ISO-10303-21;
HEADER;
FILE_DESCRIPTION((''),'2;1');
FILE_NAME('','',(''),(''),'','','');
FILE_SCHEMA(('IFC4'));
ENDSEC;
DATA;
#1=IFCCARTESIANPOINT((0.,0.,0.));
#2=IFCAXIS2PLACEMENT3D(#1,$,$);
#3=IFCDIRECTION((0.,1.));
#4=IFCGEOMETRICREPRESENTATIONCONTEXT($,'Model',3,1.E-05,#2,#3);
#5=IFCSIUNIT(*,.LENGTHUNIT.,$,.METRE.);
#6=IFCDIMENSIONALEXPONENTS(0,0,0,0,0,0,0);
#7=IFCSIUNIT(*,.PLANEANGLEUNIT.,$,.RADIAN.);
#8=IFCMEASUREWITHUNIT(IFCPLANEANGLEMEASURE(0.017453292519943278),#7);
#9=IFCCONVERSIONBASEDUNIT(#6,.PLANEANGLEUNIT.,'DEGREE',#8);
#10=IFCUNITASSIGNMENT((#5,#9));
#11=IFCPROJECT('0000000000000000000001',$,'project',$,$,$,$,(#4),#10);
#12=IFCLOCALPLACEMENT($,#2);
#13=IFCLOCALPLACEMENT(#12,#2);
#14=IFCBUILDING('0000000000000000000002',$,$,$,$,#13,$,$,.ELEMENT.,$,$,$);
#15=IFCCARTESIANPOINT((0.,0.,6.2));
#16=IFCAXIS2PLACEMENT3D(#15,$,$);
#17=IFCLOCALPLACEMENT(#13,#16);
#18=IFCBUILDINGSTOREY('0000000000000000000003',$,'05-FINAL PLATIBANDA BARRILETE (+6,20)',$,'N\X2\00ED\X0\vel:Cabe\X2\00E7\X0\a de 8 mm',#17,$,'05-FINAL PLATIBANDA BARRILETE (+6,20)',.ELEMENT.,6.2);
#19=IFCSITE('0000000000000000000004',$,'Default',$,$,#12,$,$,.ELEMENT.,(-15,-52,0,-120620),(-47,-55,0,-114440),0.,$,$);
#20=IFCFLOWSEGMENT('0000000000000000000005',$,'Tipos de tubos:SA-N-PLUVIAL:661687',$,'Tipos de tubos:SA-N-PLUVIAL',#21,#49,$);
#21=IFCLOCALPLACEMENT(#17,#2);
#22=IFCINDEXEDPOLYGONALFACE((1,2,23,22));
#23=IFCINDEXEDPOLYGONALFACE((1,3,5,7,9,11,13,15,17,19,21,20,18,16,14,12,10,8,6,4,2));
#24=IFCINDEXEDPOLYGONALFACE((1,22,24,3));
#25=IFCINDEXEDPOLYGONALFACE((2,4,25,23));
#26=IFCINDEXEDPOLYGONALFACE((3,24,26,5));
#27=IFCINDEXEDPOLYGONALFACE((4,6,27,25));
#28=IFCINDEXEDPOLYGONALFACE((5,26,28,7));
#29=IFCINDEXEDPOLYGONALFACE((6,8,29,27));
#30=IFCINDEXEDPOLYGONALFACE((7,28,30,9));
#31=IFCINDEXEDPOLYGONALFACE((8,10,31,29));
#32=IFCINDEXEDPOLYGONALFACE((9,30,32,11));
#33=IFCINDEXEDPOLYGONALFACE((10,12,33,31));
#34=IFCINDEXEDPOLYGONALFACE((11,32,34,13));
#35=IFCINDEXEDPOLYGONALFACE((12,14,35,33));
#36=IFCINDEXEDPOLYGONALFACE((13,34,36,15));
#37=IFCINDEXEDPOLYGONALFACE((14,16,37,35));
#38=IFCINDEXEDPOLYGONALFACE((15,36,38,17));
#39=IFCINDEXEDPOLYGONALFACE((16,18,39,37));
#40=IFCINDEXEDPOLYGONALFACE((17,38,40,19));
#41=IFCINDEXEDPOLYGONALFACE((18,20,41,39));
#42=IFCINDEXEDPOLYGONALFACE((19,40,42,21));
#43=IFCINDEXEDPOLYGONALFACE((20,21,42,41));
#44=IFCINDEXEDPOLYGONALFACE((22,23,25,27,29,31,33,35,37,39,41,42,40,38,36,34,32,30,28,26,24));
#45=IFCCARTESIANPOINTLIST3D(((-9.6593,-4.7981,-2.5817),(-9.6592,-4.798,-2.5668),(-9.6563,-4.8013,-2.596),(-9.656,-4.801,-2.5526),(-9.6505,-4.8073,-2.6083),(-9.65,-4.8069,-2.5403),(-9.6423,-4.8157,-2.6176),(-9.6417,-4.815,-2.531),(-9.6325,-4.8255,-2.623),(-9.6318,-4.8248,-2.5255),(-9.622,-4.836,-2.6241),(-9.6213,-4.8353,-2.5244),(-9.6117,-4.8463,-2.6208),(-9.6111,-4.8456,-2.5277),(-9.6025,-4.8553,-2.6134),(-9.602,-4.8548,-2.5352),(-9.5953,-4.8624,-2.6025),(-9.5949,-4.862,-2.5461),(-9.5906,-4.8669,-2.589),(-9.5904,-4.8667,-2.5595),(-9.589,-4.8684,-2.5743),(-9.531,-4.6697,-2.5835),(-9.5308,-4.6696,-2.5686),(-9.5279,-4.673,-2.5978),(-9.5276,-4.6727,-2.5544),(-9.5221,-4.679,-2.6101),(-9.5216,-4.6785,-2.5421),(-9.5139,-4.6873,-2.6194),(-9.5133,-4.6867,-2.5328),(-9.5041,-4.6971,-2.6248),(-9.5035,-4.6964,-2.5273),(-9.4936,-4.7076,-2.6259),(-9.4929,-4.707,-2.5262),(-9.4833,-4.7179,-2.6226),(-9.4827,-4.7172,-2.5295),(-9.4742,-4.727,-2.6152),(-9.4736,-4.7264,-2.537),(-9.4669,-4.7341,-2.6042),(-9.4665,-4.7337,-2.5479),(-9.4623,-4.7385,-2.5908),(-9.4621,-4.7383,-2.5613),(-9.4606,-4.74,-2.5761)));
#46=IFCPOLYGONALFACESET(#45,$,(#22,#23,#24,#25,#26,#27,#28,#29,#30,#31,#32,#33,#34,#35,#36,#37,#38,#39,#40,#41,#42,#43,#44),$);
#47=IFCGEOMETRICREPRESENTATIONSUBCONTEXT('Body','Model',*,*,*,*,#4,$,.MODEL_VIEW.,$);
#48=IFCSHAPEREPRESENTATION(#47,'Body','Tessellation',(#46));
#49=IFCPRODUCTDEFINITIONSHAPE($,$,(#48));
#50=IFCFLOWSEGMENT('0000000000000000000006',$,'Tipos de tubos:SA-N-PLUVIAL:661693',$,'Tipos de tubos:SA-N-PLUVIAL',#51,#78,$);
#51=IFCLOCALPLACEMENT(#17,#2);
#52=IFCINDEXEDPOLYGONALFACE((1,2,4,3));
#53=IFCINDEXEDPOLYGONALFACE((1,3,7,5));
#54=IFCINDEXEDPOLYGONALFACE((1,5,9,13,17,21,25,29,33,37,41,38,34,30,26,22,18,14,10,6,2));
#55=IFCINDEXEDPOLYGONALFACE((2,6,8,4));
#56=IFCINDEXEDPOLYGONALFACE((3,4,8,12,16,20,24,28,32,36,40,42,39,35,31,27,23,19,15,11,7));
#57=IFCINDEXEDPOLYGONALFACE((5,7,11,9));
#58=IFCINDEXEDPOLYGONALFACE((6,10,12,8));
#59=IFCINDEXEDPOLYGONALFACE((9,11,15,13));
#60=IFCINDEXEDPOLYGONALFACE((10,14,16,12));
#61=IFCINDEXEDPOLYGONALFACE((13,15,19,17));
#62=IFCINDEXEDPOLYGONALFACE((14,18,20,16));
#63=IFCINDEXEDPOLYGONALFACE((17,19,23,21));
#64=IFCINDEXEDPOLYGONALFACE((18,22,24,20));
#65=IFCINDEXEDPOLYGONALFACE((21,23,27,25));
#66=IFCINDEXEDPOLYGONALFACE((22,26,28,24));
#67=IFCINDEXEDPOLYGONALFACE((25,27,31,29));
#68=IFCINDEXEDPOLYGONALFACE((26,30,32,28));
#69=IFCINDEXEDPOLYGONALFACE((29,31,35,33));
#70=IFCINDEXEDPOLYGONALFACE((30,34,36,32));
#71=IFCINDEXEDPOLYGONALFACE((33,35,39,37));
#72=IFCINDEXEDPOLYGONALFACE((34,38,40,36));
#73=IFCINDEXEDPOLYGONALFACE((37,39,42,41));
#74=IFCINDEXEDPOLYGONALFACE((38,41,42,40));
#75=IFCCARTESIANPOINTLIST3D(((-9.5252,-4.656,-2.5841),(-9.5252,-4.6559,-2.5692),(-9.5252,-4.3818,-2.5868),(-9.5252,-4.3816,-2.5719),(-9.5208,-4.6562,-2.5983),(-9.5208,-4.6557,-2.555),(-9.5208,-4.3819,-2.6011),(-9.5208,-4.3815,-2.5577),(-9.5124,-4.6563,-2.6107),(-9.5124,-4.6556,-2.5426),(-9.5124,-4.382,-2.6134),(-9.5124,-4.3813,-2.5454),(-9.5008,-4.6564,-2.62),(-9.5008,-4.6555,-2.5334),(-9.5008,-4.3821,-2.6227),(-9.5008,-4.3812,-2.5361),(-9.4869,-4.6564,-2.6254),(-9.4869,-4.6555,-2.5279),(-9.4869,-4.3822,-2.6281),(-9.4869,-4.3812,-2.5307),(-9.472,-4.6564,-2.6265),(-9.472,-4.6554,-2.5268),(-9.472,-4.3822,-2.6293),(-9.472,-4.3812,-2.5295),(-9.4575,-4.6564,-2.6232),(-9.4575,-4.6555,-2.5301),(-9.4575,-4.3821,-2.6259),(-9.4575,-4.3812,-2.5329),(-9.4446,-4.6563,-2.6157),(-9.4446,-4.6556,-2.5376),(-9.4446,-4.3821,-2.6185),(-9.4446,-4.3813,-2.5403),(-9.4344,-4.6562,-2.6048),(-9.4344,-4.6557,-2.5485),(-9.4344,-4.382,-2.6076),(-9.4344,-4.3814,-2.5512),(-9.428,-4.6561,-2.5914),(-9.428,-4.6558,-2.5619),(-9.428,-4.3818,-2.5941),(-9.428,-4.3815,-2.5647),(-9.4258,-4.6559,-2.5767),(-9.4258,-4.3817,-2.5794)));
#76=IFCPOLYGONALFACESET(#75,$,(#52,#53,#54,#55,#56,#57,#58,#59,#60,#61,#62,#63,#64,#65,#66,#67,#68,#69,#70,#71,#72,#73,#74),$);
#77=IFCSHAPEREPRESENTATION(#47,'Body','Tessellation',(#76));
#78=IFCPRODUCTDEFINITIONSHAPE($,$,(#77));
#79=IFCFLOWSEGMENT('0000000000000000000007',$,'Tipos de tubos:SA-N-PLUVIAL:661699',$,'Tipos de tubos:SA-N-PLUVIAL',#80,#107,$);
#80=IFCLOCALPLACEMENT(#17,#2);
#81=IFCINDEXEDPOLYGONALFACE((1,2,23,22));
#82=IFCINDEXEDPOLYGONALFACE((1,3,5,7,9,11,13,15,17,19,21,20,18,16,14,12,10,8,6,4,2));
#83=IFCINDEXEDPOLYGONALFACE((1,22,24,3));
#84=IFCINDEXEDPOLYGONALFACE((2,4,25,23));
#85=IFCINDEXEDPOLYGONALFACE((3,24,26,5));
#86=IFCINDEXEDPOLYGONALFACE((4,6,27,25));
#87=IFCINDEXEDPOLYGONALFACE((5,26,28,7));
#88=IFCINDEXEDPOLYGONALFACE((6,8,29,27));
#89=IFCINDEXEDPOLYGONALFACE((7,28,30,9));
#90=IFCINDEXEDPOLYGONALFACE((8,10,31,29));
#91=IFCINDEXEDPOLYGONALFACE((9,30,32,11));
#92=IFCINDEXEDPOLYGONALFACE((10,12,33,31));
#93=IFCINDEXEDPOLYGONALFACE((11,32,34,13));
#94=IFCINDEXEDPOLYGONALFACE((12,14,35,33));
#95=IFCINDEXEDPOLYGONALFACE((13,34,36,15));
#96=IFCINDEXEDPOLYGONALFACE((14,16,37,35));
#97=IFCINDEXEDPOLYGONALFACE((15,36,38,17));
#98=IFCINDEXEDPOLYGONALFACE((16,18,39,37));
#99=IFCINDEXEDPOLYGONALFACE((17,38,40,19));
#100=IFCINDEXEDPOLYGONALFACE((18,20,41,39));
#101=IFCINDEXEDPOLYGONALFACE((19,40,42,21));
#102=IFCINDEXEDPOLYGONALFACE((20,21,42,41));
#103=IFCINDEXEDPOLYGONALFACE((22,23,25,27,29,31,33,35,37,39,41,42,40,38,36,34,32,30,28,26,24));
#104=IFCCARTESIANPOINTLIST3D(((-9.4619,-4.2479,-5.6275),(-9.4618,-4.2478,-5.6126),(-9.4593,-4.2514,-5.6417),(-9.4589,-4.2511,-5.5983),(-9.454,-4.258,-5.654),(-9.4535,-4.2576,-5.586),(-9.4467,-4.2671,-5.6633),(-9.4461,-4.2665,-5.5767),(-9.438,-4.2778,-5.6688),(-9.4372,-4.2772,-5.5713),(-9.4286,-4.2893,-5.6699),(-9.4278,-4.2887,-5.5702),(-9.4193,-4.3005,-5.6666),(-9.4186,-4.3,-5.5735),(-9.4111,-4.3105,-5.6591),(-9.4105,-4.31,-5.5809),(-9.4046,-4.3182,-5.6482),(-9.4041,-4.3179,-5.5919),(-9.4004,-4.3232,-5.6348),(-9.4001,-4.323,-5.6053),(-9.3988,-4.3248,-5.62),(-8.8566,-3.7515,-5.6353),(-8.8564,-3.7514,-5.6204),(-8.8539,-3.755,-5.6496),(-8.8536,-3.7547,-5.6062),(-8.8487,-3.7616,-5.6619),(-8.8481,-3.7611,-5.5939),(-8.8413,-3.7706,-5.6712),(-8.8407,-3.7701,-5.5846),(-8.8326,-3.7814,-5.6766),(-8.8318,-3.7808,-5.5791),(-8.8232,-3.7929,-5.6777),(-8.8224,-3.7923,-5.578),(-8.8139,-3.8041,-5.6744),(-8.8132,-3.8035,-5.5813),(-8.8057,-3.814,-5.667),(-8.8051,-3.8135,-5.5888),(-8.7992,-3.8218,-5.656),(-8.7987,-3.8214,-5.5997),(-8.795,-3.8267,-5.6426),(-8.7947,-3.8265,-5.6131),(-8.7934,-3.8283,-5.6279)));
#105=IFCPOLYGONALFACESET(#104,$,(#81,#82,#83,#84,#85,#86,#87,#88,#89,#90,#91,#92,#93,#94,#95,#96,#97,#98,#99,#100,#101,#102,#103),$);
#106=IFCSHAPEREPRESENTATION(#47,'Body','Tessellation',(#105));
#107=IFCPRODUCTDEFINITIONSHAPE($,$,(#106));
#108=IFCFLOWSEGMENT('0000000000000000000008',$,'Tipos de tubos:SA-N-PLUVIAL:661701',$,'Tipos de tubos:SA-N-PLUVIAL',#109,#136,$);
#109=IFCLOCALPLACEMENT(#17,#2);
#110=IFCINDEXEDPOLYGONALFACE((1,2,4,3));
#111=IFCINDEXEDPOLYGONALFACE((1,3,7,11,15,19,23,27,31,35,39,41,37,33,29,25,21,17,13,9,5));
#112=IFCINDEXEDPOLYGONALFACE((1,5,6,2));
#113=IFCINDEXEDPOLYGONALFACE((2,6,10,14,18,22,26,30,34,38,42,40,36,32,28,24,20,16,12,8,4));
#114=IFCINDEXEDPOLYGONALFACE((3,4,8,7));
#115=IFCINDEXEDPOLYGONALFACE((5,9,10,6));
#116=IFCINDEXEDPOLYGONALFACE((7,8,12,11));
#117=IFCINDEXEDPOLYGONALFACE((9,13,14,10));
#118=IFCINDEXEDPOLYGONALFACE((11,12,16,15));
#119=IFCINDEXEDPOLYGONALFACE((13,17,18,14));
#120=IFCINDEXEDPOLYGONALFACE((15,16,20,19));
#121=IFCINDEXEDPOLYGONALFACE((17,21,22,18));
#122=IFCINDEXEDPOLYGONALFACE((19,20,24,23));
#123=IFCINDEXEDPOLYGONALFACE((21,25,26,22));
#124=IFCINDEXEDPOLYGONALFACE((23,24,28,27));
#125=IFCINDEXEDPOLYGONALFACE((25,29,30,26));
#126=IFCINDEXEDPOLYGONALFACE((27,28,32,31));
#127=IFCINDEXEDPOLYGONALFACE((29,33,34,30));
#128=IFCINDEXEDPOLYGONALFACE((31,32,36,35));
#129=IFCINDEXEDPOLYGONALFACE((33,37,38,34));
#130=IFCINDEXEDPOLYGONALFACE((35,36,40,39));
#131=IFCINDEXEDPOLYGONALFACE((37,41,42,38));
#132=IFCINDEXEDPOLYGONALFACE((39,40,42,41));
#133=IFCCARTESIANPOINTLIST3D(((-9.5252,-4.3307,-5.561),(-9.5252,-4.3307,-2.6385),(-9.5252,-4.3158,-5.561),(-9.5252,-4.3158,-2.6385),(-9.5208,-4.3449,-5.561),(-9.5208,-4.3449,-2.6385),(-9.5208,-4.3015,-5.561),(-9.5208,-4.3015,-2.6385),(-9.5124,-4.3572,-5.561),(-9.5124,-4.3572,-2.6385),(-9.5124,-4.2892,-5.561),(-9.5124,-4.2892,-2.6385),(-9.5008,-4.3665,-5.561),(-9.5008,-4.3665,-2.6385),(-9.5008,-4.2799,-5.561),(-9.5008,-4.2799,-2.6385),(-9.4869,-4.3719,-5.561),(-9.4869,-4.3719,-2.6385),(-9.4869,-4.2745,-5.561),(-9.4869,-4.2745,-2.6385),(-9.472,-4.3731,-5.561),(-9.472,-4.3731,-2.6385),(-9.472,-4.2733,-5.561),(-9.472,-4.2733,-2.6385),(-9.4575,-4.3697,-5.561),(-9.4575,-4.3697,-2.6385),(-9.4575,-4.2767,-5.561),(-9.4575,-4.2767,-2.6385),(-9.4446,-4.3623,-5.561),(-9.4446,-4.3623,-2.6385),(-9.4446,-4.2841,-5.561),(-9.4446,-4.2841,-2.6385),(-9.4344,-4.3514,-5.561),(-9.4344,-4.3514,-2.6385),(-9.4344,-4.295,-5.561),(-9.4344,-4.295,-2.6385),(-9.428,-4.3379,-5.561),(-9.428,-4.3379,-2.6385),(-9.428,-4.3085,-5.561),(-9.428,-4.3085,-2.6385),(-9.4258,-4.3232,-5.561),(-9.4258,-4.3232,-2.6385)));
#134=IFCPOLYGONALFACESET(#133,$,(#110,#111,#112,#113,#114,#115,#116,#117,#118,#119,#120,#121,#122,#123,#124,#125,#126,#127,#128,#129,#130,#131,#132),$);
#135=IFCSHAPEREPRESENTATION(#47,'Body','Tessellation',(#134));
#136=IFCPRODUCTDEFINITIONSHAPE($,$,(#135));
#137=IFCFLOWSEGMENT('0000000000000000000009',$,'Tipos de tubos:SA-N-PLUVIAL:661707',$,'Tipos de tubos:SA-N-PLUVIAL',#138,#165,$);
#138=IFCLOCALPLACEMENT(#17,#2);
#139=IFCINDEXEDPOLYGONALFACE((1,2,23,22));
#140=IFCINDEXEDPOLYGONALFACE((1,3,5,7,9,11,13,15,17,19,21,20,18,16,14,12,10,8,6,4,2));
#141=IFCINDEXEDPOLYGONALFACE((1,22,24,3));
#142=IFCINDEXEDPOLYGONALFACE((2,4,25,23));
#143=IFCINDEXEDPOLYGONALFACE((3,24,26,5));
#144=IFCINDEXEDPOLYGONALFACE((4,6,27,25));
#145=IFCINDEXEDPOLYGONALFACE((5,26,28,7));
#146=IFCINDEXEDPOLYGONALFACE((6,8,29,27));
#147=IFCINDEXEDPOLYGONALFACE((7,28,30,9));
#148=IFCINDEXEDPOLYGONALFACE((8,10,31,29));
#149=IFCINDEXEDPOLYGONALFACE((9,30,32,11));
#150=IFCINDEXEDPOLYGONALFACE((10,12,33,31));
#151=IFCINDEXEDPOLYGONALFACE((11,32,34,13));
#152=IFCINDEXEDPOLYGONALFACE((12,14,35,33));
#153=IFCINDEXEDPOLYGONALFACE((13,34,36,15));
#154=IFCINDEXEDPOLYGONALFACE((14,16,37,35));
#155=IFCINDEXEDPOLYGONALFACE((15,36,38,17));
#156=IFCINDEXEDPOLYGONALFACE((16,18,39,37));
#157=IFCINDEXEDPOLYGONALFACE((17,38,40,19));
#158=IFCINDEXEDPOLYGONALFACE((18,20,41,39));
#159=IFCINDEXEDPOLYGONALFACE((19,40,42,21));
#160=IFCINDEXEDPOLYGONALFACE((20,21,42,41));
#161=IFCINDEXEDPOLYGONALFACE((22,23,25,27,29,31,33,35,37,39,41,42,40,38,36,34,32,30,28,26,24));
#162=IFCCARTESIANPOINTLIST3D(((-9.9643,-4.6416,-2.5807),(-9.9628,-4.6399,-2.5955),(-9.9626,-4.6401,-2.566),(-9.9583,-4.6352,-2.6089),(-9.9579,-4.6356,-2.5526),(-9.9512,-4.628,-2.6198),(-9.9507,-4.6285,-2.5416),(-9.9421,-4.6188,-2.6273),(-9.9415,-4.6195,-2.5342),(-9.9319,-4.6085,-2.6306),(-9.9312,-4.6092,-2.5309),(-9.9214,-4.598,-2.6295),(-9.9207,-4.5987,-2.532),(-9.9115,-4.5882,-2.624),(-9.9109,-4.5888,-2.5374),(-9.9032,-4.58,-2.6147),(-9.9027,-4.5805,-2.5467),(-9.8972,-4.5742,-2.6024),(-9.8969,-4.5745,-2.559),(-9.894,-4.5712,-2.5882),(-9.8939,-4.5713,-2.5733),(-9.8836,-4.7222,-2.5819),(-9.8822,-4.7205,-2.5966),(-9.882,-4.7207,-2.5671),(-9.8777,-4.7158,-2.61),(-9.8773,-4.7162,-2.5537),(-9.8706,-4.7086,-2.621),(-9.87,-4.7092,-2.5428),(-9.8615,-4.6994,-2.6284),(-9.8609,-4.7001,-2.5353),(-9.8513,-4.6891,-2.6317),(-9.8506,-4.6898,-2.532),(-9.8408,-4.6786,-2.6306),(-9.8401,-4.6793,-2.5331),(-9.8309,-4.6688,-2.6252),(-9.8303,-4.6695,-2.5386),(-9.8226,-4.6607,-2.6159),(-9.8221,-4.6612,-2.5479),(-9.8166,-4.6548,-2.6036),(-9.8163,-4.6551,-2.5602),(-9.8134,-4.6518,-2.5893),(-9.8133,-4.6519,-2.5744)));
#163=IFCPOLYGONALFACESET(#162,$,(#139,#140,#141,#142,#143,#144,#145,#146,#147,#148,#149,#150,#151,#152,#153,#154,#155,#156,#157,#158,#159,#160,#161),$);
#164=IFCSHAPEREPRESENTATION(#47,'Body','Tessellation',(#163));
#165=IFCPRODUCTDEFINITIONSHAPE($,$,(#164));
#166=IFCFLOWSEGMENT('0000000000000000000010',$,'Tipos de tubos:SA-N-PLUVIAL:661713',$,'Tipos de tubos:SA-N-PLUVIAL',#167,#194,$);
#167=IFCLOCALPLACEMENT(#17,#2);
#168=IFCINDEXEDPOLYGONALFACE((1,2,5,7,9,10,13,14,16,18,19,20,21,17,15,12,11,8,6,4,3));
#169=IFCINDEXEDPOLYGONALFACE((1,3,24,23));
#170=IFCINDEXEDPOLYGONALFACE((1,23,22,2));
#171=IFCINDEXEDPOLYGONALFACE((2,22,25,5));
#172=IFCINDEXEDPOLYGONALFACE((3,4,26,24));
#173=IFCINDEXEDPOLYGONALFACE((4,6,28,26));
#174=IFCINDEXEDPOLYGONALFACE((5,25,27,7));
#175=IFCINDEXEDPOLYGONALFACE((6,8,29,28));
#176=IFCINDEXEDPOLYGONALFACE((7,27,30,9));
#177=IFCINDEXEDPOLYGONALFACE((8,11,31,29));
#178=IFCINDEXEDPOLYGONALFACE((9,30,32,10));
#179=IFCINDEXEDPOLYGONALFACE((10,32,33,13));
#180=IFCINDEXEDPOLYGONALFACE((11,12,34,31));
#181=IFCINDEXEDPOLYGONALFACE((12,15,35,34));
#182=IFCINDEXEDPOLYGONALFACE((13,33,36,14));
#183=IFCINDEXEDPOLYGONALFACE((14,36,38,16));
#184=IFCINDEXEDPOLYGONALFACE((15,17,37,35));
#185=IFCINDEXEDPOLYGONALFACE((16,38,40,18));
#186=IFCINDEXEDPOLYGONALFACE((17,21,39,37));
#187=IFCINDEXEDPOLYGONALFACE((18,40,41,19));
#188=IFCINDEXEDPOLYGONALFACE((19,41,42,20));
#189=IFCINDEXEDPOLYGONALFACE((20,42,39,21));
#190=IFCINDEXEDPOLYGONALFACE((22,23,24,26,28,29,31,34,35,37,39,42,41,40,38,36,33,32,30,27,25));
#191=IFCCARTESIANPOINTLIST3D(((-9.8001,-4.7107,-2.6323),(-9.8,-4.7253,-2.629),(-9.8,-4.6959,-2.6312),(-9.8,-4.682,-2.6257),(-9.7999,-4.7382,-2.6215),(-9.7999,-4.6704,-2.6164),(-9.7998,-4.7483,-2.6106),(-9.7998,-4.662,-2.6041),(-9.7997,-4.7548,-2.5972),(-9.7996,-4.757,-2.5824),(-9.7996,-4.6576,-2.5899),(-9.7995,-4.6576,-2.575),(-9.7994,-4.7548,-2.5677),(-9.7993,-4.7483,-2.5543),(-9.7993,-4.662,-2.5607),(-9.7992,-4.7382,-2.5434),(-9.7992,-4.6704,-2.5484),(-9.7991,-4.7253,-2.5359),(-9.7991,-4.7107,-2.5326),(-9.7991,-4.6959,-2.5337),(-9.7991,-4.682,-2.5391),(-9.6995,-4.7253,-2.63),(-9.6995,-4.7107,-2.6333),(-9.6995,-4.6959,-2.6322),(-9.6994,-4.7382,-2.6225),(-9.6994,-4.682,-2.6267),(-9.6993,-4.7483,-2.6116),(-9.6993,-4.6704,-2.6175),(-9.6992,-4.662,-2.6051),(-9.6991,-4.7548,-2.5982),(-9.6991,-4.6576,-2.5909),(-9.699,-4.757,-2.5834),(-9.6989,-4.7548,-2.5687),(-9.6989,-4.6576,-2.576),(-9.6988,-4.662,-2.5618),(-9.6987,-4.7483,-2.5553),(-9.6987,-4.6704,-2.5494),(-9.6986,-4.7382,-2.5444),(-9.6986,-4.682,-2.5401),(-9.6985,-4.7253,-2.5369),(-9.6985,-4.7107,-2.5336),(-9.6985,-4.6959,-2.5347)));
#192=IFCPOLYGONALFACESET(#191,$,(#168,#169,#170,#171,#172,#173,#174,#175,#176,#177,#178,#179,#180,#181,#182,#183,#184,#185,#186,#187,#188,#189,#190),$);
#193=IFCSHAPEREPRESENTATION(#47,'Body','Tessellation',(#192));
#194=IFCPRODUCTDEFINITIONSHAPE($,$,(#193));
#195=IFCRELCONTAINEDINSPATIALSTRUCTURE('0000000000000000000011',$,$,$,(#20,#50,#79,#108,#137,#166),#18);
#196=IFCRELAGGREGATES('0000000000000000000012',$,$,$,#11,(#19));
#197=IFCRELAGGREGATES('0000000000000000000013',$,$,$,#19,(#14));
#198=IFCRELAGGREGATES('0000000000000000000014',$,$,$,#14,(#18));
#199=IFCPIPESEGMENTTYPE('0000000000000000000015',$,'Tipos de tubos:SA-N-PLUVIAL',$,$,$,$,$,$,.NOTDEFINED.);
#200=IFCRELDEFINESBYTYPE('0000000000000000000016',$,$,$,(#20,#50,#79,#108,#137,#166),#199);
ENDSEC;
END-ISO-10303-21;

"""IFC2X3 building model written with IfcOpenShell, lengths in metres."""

from ifc_helpers import new_model, entity, si_unit, converted_unit, direction, frame, frame_2d, origin, origin_2d_with_axis, place, context, subcontext, project, spatial, circle, extrude, type_object, element, save


model = new_model("IFC2X3")

# Units and contexts
model_context = context("Model", 3, precision=1e-05, world=origin(), true_north=direction((0.0, 1.0)))
body_context = subcontext(model_context, "Body", "Model", "MODEL_VIEW")
ifc_project = project(units=[si_unit("LENGTHUNIT", "METRE"), converted_unit("PLANEANGLEUNIT", "DEGREE", entity("IfcPlaneAngleMeasure", 0.017453292519943278), si_unit("PLANEANGLEUNIT", "RADIAN"), dimensions=[0, 0, 0, 0, 0, 0, 0])], contexts=[model_context])

# Site, building, storey
site_placement = place(None, origin())
site = spatial("IfcSite", under=ifc_project, at=site_placement, Name="Default", CompositionType="ELEMENT", RefLatitude=(-15, -52, 0, -120620), RefLongitude=(-47, -55, 0, -114440), RefElevation=0.0)
building_placement = place(site_placement, origin())
building = spatial("IfcBuilding", under=site, at=building_placement, CompositionType="ELEMENT")
storey_placement = place(building_placement, frame((0.0, 0.0, 6.2)))
storey = spatial("IfcBuildingStorey", under=building, at=storey_placement, Name="05-FINAL PLATIBANDA BARRILETE (+6,20)", ObjectType="Nível:Cabeça de 8 mm", LongName="05-FINAL PLATIBANDA BARRILETE (+6,20)", CompositionType="ELEMENT", Elevation=6.2)

# Flow segments
pipe_segment_type_1 = type_object("IfcPipeSegmentType", Name="Tipos de tubos:SA-N-PLUVIAL", PredefinedType="NOTDEFINED")
flow_segment_1_placement = place(storey_placement, origin())
element("IfcFlowSegment", 1, at=flow_segment_1_placement, inside=storey, type_object=pipe_segment_type_1, Name="Tipos de tubos:SA-N-PLUVIAL:661687", ObjectType="Tipos de tubos:SA-N-PLUVIAL", context=body_context, shape_type="SweptSolid", body=[
    extrude(circle(Radius=0.05, at=frame_2d((0.0, 0.0), x_axis=(1.0, 0.0))), frame((-9.6243, -4.833, -2.5743), z_axis=(0.707071, 0.707073, -0.009885), x_axis=(0.707108, -0.707106, 0.0)), (0.0, 0.0, 1.0), 0.1816),
])
flow_segment_2_placement = place(storey_placement, origin())
element("IfcFlowSegment", 2, at=flow_segment_2_placement, inside=storey, type_object=pipe_segment_type_1, Name="Tipos de tubos:SA-N-PLUVIAL:661693", ObjectType="Tipos de tubos:SA-N-PLUVIAL", context=body_context, shape_type="SweptSolid", body=[
    extrude(circle(Radius=0.05, at=origin_2d_with_axis()), frame((-9.4758, -4.3817, -2.5794), z_axis=(0.000001, -0.99995, 0.01), x_axis=(1.0, 0.000001, 0.0)), (0.0, 0.0, 1.0), 0.2743),
])
flow_segment_3_placement = place(storey_placement, origin())
element("IfcFlowSegment", 3, at=flow_segment_3_placement, inside=storey, type_object=pipe_segment_type_1, Name="Tipos de tubos:SA-N-PLUVIAL:661699", ObjectType="Tipos de tubos:SA-N-PLUVIAL", context=body_context, shape_type="SweptSolid", body=[
    extrude(circle(Radius=0.05, at=frame_2d((0.0, 0.0), x_axis=(1.0, 0.0))), frame((-9.4305, -4.2861, -5.62), z_axis=(0.773213, 0.634068, -0.01), x_axis=(0.6341, -0.773251, 0.0)), (0.0, 0.0, 1.0), 0.7829),
])
flow_segment_4_placement = place(storey_placement, origin())
element("IfcFlowSegment", 4, at=flow_segment_4_placement, inside=storey, type_object=pipe_segment_type_1, Name="Tipos de tubos:SA-N-PLUVIAL:661701", ObjectType="Tipos de tubos:SA-N-PLUVIAL", context=body_context, shape_type="SweptSolid", body=[
    extrude(circle(Radius=0.05, at=origin_2d_with_axis()), frame((-9.4758, -4.3232, -5.561)), (0.0, 0.0, 1.0), 2.9225),
])
flow_segment_5_placement = place(storey_placement, origin())
element("IfcFlowSegment", 5, at=flow_segment_5_placement, inside=storey, type_object=pipe_segment_type_1, Name="Tipos de tubos:SA-N-PLUVIAL:661707", ObjectType="Tipos de tubos:SA-N-PLUVIAL", context=body_context, shape_type="SweptSolid", body=[
    extrude(circle(Radius=0.05, at=origin_2d_with_axis()), frame((-9.8483, -4.6868, -2.5819), z_axis=(-0.707072, 0.707071, 0.01), x_axis=(-0.707106, -0.707107, 0.0)), (0.0, 0.0, 1.0), 0.114),
])
flow_segment_6_placement = place(storey_placement, origin())
element("IfcFlowSegment", 6, at=flow_segment_6_placement, inside=storey, type_object=pipe_segment_type_1, Name="Tipos de tubos:SA-N-PLUVIAL:661713", ObjectType="Tipos de tubos:SA-N-PLUVIAL", context=body_context, shape_type="SweptSolid", body=[
    extrude(circle(Radius=0.05, at=frame_2d((0.0, 0.0), x_axis=(1.0, 0.0))), frame((-9.699, -4.707, -2.5834), z_axis=(-0.99995, -0.000001, 0.01), x_axis=(0.000001, -1.0, 0.0)), (0.0, 0.0, 1.0), 0.1006),
])

save(model, "model.ifc")
